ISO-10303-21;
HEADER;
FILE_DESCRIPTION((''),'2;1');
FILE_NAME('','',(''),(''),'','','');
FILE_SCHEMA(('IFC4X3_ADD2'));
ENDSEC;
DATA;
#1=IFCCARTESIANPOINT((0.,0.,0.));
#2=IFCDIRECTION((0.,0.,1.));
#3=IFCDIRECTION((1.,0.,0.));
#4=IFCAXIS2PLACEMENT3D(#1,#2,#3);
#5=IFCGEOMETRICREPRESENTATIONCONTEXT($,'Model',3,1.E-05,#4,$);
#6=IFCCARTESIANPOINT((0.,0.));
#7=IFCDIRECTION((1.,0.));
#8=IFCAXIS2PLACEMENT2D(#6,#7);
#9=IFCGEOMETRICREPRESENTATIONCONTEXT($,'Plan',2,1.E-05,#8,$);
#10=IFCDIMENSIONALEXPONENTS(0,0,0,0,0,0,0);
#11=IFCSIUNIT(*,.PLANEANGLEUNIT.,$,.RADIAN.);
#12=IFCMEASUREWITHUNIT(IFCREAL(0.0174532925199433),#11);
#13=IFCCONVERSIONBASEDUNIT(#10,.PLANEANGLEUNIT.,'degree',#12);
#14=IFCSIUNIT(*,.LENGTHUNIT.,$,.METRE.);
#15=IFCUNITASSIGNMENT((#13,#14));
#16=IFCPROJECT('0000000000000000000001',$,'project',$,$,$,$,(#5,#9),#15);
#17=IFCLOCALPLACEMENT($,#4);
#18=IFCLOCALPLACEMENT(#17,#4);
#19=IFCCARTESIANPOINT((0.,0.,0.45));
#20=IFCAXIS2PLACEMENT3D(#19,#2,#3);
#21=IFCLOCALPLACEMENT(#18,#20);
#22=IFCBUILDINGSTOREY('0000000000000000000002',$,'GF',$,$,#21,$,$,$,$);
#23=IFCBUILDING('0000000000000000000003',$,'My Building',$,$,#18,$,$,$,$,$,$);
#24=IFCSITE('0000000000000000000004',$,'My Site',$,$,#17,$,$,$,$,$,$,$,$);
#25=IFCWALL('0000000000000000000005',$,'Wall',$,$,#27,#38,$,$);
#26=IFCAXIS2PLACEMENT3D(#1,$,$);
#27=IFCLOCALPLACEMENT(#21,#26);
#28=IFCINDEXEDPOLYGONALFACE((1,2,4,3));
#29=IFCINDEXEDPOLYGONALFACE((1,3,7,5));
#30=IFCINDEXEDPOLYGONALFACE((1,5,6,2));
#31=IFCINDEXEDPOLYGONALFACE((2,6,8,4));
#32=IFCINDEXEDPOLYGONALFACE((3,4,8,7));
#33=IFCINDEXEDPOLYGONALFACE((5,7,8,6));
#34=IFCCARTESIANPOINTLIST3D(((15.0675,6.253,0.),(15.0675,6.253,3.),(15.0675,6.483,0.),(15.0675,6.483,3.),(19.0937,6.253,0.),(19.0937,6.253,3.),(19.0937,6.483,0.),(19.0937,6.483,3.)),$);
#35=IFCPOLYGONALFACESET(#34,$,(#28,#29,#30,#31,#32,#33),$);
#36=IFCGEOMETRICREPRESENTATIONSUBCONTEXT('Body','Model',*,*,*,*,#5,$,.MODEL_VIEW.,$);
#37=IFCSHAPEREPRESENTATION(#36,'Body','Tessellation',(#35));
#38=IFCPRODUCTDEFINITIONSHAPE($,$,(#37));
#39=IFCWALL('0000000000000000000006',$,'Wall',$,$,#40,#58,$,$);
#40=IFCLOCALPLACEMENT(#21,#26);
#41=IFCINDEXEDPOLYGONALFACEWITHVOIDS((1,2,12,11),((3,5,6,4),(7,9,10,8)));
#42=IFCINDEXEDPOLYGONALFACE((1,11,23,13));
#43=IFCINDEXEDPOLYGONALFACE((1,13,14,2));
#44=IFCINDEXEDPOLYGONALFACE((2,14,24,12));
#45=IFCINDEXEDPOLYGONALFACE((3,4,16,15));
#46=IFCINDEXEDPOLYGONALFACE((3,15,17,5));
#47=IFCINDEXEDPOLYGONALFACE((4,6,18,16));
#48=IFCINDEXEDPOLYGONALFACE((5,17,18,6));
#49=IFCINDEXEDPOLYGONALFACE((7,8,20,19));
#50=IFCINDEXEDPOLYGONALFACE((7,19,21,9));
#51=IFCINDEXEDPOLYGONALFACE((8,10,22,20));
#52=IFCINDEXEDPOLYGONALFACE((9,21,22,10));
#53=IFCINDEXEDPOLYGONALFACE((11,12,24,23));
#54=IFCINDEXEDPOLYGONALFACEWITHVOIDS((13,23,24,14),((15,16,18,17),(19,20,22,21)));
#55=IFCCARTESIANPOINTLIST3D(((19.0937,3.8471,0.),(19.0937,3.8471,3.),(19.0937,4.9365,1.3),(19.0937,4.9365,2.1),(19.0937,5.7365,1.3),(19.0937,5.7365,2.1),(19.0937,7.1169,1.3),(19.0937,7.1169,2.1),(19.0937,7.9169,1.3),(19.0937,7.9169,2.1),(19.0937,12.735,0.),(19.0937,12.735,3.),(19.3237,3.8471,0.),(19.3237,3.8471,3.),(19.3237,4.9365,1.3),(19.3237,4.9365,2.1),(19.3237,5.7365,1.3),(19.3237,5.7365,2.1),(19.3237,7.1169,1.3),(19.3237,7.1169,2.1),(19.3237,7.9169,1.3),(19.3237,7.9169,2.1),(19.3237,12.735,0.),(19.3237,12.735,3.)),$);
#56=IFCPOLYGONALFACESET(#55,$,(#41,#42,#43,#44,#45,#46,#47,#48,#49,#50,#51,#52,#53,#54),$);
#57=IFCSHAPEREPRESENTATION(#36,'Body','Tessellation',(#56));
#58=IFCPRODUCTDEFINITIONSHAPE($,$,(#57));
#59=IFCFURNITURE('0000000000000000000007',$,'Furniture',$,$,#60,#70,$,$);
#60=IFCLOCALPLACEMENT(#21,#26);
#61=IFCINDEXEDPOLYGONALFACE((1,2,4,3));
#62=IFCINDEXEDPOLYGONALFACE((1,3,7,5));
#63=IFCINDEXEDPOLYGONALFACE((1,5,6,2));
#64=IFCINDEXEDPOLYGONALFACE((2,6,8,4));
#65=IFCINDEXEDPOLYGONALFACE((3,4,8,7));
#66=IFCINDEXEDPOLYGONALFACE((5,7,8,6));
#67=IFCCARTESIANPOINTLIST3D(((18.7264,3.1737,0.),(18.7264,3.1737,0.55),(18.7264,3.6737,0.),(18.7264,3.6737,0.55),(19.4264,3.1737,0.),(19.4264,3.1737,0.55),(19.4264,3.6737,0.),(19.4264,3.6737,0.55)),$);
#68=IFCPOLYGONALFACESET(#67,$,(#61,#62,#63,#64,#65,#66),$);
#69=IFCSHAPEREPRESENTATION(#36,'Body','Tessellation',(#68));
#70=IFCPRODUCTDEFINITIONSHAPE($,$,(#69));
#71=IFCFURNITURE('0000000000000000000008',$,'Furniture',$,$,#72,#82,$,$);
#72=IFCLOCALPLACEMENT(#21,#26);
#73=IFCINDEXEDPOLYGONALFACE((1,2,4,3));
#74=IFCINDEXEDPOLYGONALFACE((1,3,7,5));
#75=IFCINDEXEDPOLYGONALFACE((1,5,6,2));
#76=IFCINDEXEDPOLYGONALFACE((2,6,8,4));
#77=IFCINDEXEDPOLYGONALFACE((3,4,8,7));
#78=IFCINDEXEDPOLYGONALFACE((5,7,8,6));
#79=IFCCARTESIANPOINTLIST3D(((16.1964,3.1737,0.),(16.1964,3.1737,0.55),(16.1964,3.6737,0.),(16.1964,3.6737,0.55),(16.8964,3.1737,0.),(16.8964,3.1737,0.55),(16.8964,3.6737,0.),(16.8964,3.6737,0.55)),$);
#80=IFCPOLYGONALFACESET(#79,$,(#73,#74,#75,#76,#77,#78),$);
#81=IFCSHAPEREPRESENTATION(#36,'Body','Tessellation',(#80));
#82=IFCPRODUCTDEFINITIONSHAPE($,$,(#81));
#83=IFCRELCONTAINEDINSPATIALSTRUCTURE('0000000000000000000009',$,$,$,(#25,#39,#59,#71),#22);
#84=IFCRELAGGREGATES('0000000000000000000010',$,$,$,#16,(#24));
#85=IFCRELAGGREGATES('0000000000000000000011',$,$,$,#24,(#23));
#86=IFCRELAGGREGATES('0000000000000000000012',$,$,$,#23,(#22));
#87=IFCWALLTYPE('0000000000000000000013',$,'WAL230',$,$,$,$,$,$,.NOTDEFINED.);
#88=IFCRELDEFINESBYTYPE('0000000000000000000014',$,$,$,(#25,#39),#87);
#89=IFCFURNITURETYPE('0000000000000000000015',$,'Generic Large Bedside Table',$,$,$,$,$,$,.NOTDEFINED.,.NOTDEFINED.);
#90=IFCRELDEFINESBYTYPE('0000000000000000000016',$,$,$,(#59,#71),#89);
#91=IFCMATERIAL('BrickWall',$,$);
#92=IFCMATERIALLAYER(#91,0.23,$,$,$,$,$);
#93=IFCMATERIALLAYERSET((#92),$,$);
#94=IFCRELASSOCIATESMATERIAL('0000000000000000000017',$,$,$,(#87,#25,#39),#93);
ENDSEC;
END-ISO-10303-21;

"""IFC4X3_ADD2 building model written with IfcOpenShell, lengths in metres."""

from ifc_helpers import new_model, entity, si_unit, converted_unit, frame, origin_with_axes, origin_2d_with_axis, place, context, subcontext, project, spatial, line, indexed_curve, outline, extrude, shape, source, transform, mapped, material, layer, layer_set, layer_usage, type_object, type_shapes, element, save


model = new_model("IFC4X3_ADD2")

# Units and contexts
model_context = context("Model", 3, precision=1e-05, world=origin_with_axes())
plan_context = context("Plan", 2, precision=1e-05, world=origin_2d_with_axis())
body_context_1 = subcontext(model_context, "Body", "Model", "MODEL_VIEW")
body_context_2 = subcontext(plan_context, "Body", "Plan", "PLAN_VIEW")
ifc_project = project(units=[converted_unit("PLANEANGLEUNIT", "degree", entity("IfcReal", 0.0174532925199433), si_unit("PLANEANGLEUNIT", "RADIAN"), dimensions=[0, 0, 0, 0, 0, 0, 0]), si_unit("LENGTHUNIT", "METRE")], contexts=[model_context, plan_context])

# Site, building, storey
site_placement = place(None, origin_with_axes())
site = spatial("IfcSite", under=ifc_project, at=site_placement, Name="My Site")
building_placement = place(site_placement, origin_with_axes())
building = spatial("IfcBuilding", under=site, at=building_placement, Name="My Building")
storey_placement = place(building_placement, frame((0.0, 0.0, 0.45), z_axis=(0.0, 0.0, 1.0), x_axis=(1.0, 0.0, 0.0)))
storey = spatial("IfcBuildingStorey", under=building, at=storey_placement, Name="GF")

# Shared definitions
ifc_material_1 = material(Name="BrickWall")
ifc_layer_1 = layer(ifc_material_1, 0.23)
ifc_layer_set_1 = layer_set([ifc_layer_1])
wall_type_1 = type_object("IfcWallType", Name="WAL230", PredefinedType="NOTDEFINED", material=ifc_layer_set_1)

# Wall
ifc_layer_usage_1 = layer_usage(ifc_layer_set_1, "AXIS2", "POSITIVE", 0.0)
wall_1_placement = place(storey_placement, frame((15.0675, 6.253, 0.0), z_axis=(0.0, 0.0, 1.0), x_axis=(1.0, 0.0, 0.0)))
element("IfcWall", 1, at=wall_1_placement, inside=storey, type_object=wall_type_1, material=ifc_layer_usage_1, Name="Wall", context=body_context_1, shape_type="SweptSolid", body=[
    extrude(outline(indexed_curve([(0.0, 0.0), (0.0, 0.23), (4.0262, 0.23), (4.0262, 0.0), (0.0, 0.0)], self_intersect=False)), origin_with_axes(), (0.0, 0.0, 1.0), 3.0),
])

# Wall, openings
ifc_layer_usage_2 = layer_usage(ifc_layer_set_1, "AXIS2", "POSITIVE", 0.0)
wall_2_placement = place(storey_placement, frame((19.3237, 3.8471, 0.0), z_axis=(0.0, 0.0, 1.0), x_axis=(0.0, 1.0, 0.0)))
wall_2 = element("IfcWall", 2, at=wall_2_placement, inside=storey, type_object=wall_type_1, material=ifc_layer_usage_2, Name="Wall", context=body_context_1, shape_type="SweptSolid", body=[
    extrude(outline(indexed_curve([(0.0, 0.0), (0.0, 0.23), (8.8879, 0.23), (8.8879, 0.0), (0.0, 0.0)], self_intersect=False)), origin_with_axes(), (0.0, 0.0, 1.0), 3.0),
])
shared_shape_1 = source(origin_with_axes(), body_context_1, "Body", "SweptSolid", [
    extrude(outline(indexed_curve([(0.0, 0.0), (0.8, 0.0), (0.8, 0.8), (0.0, 0.8)], segments=[line(1, 2, 3, 4, 1)])), frame((-0.4, -0.6, 0.0), z_axis=(0.0, -1.0, 0.0), x_axis=(1.0, 0.0, 0.0)), (0.0, 0.0, -1.0), 1.2),
])
opening_1_placement = place(wall_2_placement, frame((1.4894, 0.0, 1.3), z_axis=(0.0, 0.0, 1.0), x_axis=(1.0, 0.0, 0.0)))
element("IfcOpeningElement", 3, at=opening_1_placement, cuts=wall_2, PredefinedType="OPENING", context=body_context_1, shape_type="MappedRepresentation", body=[
    mapped(shared_shape_1, transform((0.0, 0.0, 0.0), x_axis=(1.0, 0.0, 0.0), y_axis=(0.0, 1.0, 0.0), z_axis=(0.0, 0.0, 1.0), scale=1.0)),
])
opening_2_placement = place(wall_2_placement, frame((3.6698, 0.0, 1.3), z_axis=(0.0, 0.0, 1.0), x_axis=(1.0, 0.0, 0.0)))
element("IfcOpeningElement", 4, at=opening_2_placement, cuts=wall_2, PredefinedType="OPENING", context=body_context_1, shape_type="MappedRepresentation", body=[
    mapped(shared_shape_1, transform((0.0, 0.0, 0.0), x_axis=(1.0, 0.0, 0.0), y_axis=(0.0, 1.0, 0.0), z_axis=(0.0, 0.0, 1.0), scale=1.0)),
])

# Furniture
furniture_type_1 = type_object("IfcFurnitureType", Name="Generic Large Bedside Table", AssemblyPlace="NOTDEFINED", PredefinedType="NOTDEFINED")
shared_shape_2 = source(origin_with_axes(), body_context_1, "Body", "SweptSolid", [
    extrude(outline(indexed_curve([(0.0, 0.0), (0.7, 0.0), (0.7, 0.5), (0.0, 0.5)], segments=[line(1, 2, 3, 4, 1)])), frame((-0.35, -0.25, 0.0), z_axis=(0.0, 0.0, 1.0), x_axis=(1.0, 0.0, 0.0)), (0.0, 0.0, 1.0), 0.55),
])
shared_shape_3 = source(origin_with_axes(), body_context_2, "Body", "Curve2D", [
    entity("IfcIndexedPolyCurve", entity("IfcCartesianPointList2D", [[-0.35, -0.25], [0.35, -0.25], [0.35, 0.25], [-0.35, 0.25]]), [entity("IfcLineIndex", [1, 2, 3, 4, 1])]),
])
type_shapes(furniture_type_1, [shared_shape_2, shared_shape_3])
for number, where, z_axis, x_axis, name in (
    (5, (19.0764, 3.4237, 0.0), (0.0, 0.0, 1.0), (1.0, 0.0, 0.0), "Furniture"),
    (6, (16.5464, 3.4237, 0.0), (0.0, 0.0, 1.0), (1.0, 0.0, 0.0), "Furniture"),
):
    element("IfcFurniture", number, at=place(storey_placement, frame(where, z_axis=z_axis, x_axis=x_axis)), inside=storey, type_object=furniture_type_1, Name=name, shapes=[
        shape(body_context_1, "Body", "MappedRepresentation", [mapped(shared_shape_2, transform((0.0, 0.0, 0.0), x_axis=(1.0, 0.0, 0.0), y_axis=(0.0, 1.0, 0.0), z_axis=(0.0, 0.0, 1.0), scale=1.0))]),
        shape(body_context_2, "Body", "MappedRepresentation", [mapped(shared_shape_3, transform((0.0, 0.0, 0.0), x_axis=(1.0, 0.0, 0.0), y_axis=(0.0, 1.0, 0.0), z_axis=(0.0, 0.0, 1.0), scale=1.0))]),
    ])

save(model, "model.ifc")
